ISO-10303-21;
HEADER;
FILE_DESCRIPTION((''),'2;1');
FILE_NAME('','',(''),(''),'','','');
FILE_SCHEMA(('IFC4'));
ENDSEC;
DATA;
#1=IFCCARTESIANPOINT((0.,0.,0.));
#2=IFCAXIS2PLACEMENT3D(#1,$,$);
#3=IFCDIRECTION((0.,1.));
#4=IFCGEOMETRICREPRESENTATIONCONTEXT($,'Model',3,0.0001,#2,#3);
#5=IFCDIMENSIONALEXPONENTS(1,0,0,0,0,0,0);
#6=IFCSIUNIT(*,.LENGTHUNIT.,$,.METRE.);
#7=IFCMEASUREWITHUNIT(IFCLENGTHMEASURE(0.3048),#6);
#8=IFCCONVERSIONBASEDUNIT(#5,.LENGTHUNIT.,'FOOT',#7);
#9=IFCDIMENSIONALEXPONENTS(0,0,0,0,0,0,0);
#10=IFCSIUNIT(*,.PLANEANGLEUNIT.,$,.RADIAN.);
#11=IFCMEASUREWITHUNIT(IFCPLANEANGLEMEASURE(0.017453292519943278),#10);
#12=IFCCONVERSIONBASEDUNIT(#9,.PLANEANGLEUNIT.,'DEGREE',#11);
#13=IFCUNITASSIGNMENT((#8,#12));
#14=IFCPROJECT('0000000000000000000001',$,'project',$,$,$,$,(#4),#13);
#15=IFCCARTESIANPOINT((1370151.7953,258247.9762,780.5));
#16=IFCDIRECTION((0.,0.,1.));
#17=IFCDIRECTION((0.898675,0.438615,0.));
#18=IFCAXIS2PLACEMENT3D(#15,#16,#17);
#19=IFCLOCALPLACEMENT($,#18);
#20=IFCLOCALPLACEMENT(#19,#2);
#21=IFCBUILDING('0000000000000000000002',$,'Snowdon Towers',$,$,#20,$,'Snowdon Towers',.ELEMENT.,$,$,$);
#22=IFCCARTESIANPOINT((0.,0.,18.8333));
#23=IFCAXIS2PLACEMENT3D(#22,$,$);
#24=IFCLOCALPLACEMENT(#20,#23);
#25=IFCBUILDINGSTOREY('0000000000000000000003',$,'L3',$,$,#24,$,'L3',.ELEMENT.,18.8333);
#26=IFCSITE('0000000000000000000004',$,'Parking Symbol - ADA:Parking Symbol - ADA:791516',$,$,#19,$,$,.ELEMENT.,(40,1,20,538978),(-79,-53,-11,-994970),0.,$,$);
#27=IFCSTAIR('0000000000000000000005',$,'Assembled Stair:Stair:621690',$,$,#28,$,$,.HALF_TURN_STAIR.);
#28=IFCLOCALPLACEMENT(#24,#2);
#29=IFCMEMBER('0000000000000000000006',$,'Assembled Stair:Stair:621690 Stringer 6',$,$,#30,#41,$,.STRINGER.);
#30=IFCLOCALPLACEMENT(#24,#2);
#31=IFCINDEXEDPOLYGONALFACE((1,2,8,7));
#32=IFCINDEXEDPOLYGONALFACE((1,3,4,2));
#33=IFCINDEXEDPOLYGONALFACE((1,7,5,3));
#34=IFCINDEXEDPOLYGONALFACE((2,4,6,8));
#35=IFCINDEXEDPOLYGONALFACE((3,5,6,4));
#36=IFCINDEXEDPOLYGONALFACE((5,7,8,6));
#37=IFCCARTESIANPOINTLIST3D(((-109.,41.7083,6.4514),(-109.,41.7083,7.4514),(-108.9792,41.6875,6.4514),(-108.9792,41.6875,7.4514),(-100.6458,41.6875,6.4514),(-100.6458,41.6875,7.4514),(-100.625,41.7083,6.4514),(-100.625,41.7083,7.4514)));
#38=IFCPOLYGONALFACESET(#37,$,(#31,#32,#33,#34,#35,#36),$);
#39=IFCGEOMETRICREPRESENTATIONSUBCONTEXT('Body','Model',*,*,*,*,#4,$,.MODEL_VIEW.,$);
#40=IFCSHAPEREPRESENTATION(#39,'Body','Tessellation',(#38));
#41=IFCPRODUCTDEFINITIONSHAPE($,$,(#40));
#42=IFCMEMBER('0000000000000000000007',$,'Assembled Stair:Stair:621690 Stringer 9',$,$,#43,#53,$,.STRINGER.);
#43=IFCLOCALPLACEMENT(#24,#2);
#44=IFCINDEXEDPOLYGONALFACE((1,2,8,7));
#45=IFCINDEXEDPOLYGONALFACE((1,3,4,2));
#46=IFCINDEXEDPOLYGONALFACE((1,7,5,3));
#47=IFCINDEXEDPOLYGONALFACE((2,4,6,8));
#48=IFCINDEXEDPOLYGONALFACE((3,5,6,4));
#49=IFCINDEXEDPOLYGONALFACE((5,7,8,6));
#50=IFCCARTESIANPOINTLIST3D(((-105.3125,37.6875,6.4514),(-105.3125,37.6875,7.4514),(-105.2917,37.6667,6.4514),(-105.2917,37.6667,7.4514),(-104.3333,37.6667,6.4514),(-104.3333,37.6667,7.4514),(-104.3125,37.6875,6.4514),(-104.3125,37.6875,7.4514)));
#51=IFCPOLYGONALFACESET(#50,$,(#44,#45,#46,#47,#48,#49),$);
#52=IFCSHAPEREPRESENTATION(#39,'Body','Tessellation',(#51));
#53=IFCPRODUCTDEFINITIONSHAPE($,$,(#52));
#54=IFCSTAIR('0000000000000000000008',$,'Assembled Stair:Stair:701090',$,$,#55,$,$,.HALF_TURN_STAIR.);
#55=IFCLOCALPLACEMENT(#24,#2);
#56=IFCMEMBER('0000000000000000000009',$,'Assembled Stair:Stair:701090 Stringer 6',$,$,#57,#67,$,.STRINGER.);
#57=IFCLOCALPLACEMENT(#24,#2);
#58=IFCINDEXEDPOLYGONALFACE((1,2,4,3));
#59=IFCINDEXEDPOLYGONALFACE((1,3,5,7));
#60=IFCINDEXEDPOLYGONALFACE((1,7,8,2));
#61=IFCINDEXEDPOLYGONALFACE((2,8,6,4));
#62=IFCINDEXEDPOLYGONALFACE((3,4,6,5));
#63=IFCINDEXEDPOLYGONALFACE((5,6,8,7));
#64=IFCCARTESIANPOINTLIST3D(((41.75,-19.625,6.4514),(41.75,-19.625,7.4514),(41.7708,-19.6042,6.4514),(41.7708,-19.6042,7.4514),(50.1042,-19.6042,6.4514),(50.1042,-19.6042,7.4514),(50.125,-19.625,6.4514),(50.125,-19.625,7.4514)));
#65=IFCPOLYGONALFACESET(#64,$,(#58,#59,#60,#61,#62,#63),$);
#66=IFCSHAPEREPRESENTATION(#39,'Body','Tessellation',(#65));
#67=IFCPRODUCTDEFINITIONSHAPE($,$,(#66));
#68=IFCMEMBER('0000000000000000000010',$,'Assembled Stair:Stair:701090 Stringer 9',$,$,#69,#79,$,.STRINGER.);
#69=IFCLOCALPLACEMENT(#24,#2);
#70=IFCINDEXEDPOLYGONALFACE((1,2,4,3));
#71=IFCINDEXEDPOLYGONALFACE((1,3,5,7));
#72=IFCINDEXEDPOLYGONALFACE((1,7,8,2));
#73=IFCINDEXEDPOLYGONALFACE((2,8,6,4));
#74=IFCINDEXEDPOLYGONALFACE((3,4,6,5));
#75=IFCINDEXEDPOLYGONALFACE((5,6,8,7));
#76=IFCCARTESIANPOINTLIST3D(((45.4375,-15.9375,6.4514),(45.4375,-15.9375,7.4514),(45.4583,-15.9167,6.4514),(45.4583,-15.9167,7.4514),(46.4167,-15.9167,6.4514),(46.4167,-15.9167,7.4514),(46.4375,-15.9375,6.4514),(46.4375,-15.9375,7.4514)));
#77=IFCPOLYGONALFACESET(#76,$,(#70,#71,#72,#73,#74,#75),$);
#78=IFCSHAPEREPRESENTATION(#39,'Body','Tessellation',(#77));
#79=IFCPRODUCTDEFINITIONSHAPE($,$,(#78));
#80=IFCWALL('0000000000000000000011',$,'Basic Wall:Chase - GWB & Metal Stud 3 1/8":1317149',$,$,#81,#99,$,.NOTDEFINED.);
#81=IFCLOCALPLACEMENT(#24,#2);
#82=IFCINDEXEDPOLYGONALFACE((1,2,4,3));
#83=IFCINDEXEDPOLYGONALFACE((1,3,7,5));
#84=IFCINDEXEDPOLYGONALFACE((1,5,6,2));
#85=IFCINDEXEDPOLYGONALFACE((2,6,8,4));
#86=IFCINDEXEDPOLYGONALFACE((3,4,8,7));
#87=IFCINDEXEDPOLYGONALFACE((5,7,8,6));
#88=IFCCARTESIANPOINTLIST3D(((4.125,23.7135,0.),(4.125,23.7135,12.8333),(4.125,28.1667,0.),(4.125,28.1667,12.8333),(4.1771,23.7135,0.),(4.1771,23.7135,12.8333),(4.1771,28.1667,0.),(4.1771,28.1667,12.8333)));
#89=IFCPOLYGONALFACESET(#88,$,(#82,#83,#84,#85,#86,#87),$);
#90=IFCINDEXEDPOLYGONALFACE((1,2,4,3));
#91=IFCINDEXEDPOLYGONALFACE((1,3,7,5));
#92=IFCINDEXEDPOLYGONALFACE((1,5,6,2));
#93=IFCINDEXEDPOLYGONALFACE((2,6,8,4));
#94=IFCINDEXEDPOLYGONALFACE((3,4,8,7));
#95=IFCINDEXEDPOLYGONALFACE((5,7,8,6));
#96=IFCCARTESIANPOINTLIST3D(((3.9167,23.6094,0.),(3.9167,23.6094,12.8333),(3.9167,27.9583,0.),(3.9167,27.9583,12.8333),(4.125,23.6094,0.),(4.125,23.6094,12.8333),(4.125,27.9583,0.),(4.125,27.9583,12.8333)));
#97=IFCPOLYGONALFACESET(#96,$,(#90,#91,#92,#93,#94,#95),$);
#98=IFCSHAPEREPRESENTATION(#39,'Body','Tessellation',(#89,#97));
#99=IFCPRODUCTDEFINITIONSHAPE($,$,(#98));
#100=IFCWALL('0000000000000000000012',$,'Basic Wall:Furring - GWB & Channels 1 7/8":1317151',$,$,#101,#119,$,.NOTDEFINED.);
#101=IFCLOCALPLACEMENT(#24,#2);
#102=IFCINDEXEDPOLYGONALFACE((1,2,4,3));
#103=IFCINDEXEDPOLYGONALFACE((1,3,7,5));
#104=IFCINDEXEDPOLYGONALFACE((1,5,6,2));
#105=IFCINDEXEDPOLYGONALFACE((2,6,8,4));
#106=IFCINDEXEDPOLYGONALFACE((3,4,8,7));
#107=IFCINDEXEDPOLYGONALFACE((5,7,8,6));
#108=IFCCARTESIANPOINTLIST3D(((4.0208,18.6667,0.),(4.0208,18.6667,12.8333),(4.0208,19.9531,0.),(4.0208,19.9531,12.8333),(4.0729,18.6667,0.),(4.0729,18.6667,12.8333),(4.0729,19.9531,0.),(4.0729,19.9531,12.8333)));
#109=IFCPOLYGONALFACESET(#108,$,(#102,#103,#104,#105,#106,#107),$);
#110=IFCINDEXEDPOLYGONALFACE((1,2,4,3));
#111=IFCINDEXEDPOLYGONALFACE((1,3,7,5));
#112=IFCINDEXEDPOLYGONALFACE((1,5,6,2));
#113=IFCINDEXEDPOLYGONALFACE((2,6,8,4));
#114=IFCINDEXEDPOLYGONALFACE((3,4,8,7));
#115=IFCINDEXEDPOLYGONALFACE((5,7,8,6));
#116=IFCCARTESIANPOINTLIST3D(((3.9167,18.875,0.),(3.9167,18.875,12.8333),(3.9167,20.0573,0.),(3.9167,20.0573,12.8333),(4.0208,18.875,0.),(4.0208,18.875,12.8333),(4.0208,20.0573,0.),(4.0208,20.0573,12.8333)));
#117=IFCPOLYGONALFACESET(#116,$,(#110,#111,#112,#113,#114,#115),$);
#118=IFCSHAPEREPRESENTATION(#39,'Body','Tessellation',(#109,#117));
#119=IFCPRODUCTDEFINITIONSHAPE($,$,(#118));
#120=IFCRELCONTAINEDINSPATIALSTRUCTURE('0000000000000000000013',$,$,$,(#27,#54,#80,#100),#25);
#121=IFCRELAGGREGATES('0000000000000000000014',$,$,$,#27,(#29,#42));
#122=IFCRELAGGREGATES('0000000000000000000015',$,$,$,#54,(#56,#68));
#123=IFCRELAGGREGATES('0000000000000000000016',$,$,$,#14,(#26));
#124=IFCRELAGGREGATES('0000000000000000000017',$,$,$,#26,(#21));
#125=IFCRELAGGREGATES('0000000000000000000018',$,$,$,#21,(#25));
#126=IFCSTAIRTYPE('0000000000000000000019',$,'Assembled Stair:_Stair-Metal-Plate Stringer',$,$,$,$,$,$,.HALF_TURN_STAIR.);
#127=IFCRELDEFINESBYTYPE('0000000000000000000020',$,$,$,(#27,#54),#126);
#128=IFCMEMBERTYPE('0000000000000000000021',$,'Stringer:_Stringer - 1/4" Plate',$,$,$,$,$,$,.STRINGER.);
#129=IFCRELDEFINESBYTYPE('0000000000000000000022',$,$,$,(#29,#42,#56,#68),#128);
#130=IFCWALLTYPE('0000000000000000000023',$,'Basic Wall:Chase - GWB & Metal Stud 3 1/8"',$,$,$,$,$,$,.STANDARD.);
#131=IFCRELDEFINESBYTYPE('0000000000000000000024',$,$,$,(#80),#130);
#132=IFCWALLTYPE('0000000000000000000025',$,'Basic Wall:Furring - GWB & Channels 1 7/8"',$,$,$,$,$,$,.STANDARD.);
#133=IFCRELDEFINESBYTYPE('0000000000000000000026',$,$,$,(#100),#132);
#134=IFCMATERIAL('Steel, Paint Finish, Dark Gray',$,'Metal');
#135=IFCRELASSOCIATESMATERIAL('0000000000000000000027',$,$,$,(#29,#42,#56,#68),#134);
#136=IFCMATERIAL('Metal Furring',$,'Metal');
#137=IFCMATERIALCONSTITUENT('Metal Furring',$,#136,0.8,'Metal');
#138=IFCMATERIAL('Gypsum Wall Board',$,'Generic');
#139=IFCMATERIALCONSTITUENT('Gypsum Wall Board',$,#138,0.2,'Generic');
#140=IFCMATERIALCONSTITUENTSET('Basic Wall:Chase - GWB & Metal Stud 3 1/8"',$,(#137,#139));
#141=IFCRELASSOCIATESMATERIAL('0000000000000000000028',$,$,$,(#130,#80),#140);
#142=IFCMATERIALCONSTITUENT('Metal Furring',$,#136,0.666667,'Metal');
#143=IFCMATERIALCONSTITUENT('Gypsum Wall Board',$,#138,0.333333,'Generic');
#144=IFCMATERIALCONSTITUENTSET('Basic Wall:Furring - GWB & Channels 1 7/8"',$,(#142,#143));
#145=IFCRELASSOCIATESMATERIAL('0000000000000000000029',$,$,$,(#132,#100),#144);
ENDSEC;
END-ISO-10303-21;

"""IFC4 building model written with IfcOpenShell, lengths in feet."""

from ifc_helpers import new_model, entity, si_unit, converted_unit, direction, frame, origin, place, context, subcontext, project, spatial, indexed_curve, outline, extrude, material, constituent, constituent_set, type_object, element, aggregate, save


model = new_model("IFC4")

# Units and contexts
model_context = context("Model", 3, precision=0.0001, world=origin(), true_north=direction((0.0, 1.0)))
body_context = subcontext(model_context, "Body", "Model", "MODEL_VIEW")
ifc_project = project(units=[converted_unit("LENGTHUNIT", "FOOT", entity("IfcLengthMeasure", 0.3048), si_unit("LENGTHUNIT", "METRE"), dimensions=[1, 0, 0, 0, 0, 0, 0]), converted_unit("PLANEANGLEUNIT", "DEGREE", entity("IfcPlaneAngleMeasure", 0.017453292519943278), si_unit("PLANEANGLEUNIT", "RADIAN"), dimensions=[0, 0, 0, 0, 0, 0, 0])], contexts=[model_context])

# Site, building, storey
site_placement = place(None, frame((1370151.7953, 258247.9762, 780.5), z_axis=(0.0, 0.0, 1.0), x_axis=(0.898675, 0.438615, 0.0)))
site = spatial("IfcSite", under=ifc_project, at=site_placement, Name="Parking Symbol - ADA:Parking Symbol - ADA:791516", CompositionType="ELEMENT", RefLatitude=(40, 1, 20, 538978), RefLongitude=(-79, -53, -11, -994970), RefElevation=0.0)
building_placement = place(site_placement, origin())
building = spatial("IfcBuilding", under=site, at=building_placement, Name="Snowdon Towers", LongName="Snowdon Towers", CompositionType="ELEMENT")
storey_placement = place(building_placement, frame((0.0, 0.0, 18.8333)))
storey = spatial("IfcBuildingStorey", under=building, at=storey_placement, Name="L3", LongName="L3", CompositionType="ELEMENT", Elevation=18.8333)

# Stairs, members
stair_type = type_object("IfcStairType", Name="Assembled Stair:_Stair-Metal-Plate Stringer", PredefinedType="HALF_TURN_STAIR")
stair_1_placement = place(storey_placement, origin())
stair_1 = element("IfcStair", 1, at=stair_1_placement, inside=storey, type_object=stair_type, Name="Assembled Stair:Stair:621690", PredefinedType="HALF_TURN_STAIR")
ifc_material_1 = material(Name="Steel, Paint Finish, Dark Gray", Category="Metal")
member_type = type_object("IfcMemberType", Name="Stringer:_Stringer - 1/4\" Plate", PredefinedType="STRINGER")
member_1_placement = place(stair_1_placement, origin())
member_1 = element("IfcMember", 2, at=member_1_placement, type_object=member_type, material=ifc_material_1, Name="Assembled Stair:Stair:621690 Stringer 6", PredefinedType="STRINGER", context=body_context, shape_type="SweptSolid", body=[
    extrude(outline(indexed_curve([(-4.1875, -0.0104), (4.1875, -0.0104), (4.1667, 0.0104), (-4.1667, 0.0104), (-4.1875, -0.0104)], self_intersect=False)), frame((-104.8125, 41.6979, 6.4514), z_axis=(0.0, 0.0, 1.0), x_axis=(-1.0, 0.0, 0.0)), (0.0, 0.0, 1.0), 1.0),
])
member_2_placement = place(stair_1_placement, origin())
member_2 = element("IfcMember", 3, at=member_2_placement, type_object=member_type, material=ifc_material_1, Name="Assembled Stair:Stair:621690 Stringer 9", PredefinedType="STRINGER", context=body_context, shape_type="SweptSolid", body=[
    extrude(outline(indexed_curve([(-0.4792, -0.0104), (0.4792, -0.0104), (0.5, 0.0104), (-0.5, 0.0104), (-0.4792, -0.0104)], self_intersect=False)), frame((-104.8125, 37.6771, 6.4514)), (0.0, 0.0, 1.0), 1.0),
])
stair_2_placement = place(storey_placement, origin())
stair_2 = element("IfcStair", 4, at=stair_2_placement, inside=storey, type_object=stair_type, Name="Assembled Stair:Stair:701090", PredefinedType="HALF_TURN_STAIR")
member_3_placement = place(stair_2_placement, origin())
member_3 = element("IfcMember", 5, at=member_3_placement, type_object=member_type, material=ifc_material_1, Name="Assembled Stair:Stair:701090 Stringer 6", PredefinedType="STRINGER", context=body_context, shape_type="SweptSolid", body=[
    extrude(outline(indexed_curve([(-4.1875, -0.0104), (4.1875, -0.0104), (4.1667, 0.0104), (-4.1667, 0.0104), (-4.1875, -0.0104)], self_intersect=False)), frame((45.9375, -19.6146, 6.4514)), (0.0, 0.0, 1.0), 1.0),
])
member_4_placement = place(stair_2_placement, origin())
member_4 = element("IfcMember", 6, at=member_4_placement, type_object=member_type, material=ifc_material_1, Name="Assembled Stair:Stair:701090 Stringer 9", PredefinedType="STRINGER", context=body_context, shape_type="SweptSolid", body=[
    extrude(outline(indexed_curve([(-0.4792, -0.0104), (0.4792, -0.0104), (0.5, 0.0104), (-0.5, 0.0104), (-0.4792, -0.0104)], self_intersect=False)), frame((45.9375, -15.9271, 6.4514), z_axis=(0.0, 0.0, 1.0), x_axis=(-1.0, 0.0, 0.0)), (0.0, 0.0, 1.0), 1.0),
])

# Shared definitions
ifc_material_2 = material(Name="Gypsum Wall Board", Category="Generic")

# Wall
ifc_material_3 = material(Name="Metal Furring", Category="Metal")
ifc_constituent_1 = constituent(ifc_material_3, Name="Metal Furring", Category="Metal", fraction=0.8)
ifc_constituent_2 = constituent(ifc_material_2, Name="Gypsum Wall Board", Category="Generic", fraction=0.2)
ifc_constituent_set_1 = constituent_set(constituents=[ifc_constituent_1, ifc_constituent_2], Name="Basic Wall:Chase - GWB & Metal Stud 3 1/8\"")
wall_type_1 = type_object("IfcWallType", Name="Basic Wall:Chase - GWB & Metal Stud 3 1/8\"", PredefinedType="STANDARD", material=ifc_constituent_set_1)
wall_1_placement = place(storey_placement, frame((4.0469, 27.9583, 0.0), z_axis=(0.0, 0.0, 1.0), x_axis=(0.0, -1.0, 0.0)))
element("IfcWall", 7, at=wall_1_placement, inside=storey, type_object=wall_type_1, material=ifc_constituent_set_1, Name="Basic Wall:Chase - GWB & Metal Stud 3 1/8\":1317149", PredefinedType="NOTDEFINED", context=body_context, shape_type="SweptSolid", body=[
    extrude(outline(indexed_curve([(-0.026, -2.2266), (0.026, -2.2266), (0.026, 2.2266), (-0.026, 2.2266), (-0.026, -2.2266)], self_intersect=False)), frame((2.0182, 0.1042, 0.0), z_axis=(0.0, 0.0, 1.0), x_axis=(0.0, -1.0, 0.0)), (0.0, 0.0, 1.0), 12.8333),
    extrude(outline(indexed_curve([(-0.1042, -2.1745), (0.1042, -2.1745), (0.1042, 2.1745), (-0.1042, 2.1745), (-0.1042, -2.1745)], self_intersect=False)), frame((2.1745, -0.026, 0.0), z_axis=(0.0, 0.0, 1.0), x_axis=(0.0, 1.0, 0.0)), (0.0, 0.0, 1.0), 12.8333),
])

# Wall
ifc_constituent_3 = constituent(ifc_material_3, Name="Metal Furring", Category="Metal", fraction=0.666667)
ifc_constituent_4 = constituent(ifc_material_2, Name="Gypsum Wall Board", Category="Generic", fraction=0.333333)
ifc_constituent_set_2 = constituent_set(constituents=[ifc_constituent_3, ifc_constituent_4], Name="Basic Wall:Furring - GWB & Channels 1 7/8\"")
wall_type_2 = type_object("IfcWallType", Name="Basic Wall:Furring - GWB & Channels 1 7/8\"", PredefinedType="STANDARD", material=ifc_constituent_set_2)
wall_2_placement = place(storey_placement, frame((3.9948, 18.875, 0.0), z_axis=(0.0, 0.0, 1.0), x_axis=(0.0, 1.0, 0.0)))
element("IfcWall", 8, at=wall_2_placement, inside=storey, type_object=wall_type_2, material=ifc_constituent_set_2, Name="Basic Wall:Furring - GWB & Channels 1 7/8\":1317151", PredefinedType="NOTDEFINED", context=body_context, shape_type="SweptSolid", body=[
    extrude(outline(indexed_curve([(-0.026, -0.6432), (0.026, -0.6432), (0.026, 0.6432), (-0.026, 0.6432), (-0.026, -0.6432)], self_intersect=False)), frame((0.4349, -0.0521, 0.0), z_axis=(0.0, 0.0, 1.0), x_axis=(0.0, 1.0, 0.0)), (0.0, 0.0, 1.0), 12.8333),
    extrude(outline(indexed_curve([(-0.0521, -0.5911), (0.0521, -0.5911), (0.0521, 0.5911), (-0.0521, 0.5911), (-0.0521, -0.5911)], self_intersect=False)), frame((0.5911, 0.026, 0.0), z_axis=(0.0, 0.0, 1.0), x_axis=(0.0, 1.0, 0.0)), (0.0, 0.0, 1.0), 12.8333),
])

aggregate(stair_1, [member_1, member_2])
aggregate(stair_2, [member_3, member_4])

save(model, "model.ifc")
